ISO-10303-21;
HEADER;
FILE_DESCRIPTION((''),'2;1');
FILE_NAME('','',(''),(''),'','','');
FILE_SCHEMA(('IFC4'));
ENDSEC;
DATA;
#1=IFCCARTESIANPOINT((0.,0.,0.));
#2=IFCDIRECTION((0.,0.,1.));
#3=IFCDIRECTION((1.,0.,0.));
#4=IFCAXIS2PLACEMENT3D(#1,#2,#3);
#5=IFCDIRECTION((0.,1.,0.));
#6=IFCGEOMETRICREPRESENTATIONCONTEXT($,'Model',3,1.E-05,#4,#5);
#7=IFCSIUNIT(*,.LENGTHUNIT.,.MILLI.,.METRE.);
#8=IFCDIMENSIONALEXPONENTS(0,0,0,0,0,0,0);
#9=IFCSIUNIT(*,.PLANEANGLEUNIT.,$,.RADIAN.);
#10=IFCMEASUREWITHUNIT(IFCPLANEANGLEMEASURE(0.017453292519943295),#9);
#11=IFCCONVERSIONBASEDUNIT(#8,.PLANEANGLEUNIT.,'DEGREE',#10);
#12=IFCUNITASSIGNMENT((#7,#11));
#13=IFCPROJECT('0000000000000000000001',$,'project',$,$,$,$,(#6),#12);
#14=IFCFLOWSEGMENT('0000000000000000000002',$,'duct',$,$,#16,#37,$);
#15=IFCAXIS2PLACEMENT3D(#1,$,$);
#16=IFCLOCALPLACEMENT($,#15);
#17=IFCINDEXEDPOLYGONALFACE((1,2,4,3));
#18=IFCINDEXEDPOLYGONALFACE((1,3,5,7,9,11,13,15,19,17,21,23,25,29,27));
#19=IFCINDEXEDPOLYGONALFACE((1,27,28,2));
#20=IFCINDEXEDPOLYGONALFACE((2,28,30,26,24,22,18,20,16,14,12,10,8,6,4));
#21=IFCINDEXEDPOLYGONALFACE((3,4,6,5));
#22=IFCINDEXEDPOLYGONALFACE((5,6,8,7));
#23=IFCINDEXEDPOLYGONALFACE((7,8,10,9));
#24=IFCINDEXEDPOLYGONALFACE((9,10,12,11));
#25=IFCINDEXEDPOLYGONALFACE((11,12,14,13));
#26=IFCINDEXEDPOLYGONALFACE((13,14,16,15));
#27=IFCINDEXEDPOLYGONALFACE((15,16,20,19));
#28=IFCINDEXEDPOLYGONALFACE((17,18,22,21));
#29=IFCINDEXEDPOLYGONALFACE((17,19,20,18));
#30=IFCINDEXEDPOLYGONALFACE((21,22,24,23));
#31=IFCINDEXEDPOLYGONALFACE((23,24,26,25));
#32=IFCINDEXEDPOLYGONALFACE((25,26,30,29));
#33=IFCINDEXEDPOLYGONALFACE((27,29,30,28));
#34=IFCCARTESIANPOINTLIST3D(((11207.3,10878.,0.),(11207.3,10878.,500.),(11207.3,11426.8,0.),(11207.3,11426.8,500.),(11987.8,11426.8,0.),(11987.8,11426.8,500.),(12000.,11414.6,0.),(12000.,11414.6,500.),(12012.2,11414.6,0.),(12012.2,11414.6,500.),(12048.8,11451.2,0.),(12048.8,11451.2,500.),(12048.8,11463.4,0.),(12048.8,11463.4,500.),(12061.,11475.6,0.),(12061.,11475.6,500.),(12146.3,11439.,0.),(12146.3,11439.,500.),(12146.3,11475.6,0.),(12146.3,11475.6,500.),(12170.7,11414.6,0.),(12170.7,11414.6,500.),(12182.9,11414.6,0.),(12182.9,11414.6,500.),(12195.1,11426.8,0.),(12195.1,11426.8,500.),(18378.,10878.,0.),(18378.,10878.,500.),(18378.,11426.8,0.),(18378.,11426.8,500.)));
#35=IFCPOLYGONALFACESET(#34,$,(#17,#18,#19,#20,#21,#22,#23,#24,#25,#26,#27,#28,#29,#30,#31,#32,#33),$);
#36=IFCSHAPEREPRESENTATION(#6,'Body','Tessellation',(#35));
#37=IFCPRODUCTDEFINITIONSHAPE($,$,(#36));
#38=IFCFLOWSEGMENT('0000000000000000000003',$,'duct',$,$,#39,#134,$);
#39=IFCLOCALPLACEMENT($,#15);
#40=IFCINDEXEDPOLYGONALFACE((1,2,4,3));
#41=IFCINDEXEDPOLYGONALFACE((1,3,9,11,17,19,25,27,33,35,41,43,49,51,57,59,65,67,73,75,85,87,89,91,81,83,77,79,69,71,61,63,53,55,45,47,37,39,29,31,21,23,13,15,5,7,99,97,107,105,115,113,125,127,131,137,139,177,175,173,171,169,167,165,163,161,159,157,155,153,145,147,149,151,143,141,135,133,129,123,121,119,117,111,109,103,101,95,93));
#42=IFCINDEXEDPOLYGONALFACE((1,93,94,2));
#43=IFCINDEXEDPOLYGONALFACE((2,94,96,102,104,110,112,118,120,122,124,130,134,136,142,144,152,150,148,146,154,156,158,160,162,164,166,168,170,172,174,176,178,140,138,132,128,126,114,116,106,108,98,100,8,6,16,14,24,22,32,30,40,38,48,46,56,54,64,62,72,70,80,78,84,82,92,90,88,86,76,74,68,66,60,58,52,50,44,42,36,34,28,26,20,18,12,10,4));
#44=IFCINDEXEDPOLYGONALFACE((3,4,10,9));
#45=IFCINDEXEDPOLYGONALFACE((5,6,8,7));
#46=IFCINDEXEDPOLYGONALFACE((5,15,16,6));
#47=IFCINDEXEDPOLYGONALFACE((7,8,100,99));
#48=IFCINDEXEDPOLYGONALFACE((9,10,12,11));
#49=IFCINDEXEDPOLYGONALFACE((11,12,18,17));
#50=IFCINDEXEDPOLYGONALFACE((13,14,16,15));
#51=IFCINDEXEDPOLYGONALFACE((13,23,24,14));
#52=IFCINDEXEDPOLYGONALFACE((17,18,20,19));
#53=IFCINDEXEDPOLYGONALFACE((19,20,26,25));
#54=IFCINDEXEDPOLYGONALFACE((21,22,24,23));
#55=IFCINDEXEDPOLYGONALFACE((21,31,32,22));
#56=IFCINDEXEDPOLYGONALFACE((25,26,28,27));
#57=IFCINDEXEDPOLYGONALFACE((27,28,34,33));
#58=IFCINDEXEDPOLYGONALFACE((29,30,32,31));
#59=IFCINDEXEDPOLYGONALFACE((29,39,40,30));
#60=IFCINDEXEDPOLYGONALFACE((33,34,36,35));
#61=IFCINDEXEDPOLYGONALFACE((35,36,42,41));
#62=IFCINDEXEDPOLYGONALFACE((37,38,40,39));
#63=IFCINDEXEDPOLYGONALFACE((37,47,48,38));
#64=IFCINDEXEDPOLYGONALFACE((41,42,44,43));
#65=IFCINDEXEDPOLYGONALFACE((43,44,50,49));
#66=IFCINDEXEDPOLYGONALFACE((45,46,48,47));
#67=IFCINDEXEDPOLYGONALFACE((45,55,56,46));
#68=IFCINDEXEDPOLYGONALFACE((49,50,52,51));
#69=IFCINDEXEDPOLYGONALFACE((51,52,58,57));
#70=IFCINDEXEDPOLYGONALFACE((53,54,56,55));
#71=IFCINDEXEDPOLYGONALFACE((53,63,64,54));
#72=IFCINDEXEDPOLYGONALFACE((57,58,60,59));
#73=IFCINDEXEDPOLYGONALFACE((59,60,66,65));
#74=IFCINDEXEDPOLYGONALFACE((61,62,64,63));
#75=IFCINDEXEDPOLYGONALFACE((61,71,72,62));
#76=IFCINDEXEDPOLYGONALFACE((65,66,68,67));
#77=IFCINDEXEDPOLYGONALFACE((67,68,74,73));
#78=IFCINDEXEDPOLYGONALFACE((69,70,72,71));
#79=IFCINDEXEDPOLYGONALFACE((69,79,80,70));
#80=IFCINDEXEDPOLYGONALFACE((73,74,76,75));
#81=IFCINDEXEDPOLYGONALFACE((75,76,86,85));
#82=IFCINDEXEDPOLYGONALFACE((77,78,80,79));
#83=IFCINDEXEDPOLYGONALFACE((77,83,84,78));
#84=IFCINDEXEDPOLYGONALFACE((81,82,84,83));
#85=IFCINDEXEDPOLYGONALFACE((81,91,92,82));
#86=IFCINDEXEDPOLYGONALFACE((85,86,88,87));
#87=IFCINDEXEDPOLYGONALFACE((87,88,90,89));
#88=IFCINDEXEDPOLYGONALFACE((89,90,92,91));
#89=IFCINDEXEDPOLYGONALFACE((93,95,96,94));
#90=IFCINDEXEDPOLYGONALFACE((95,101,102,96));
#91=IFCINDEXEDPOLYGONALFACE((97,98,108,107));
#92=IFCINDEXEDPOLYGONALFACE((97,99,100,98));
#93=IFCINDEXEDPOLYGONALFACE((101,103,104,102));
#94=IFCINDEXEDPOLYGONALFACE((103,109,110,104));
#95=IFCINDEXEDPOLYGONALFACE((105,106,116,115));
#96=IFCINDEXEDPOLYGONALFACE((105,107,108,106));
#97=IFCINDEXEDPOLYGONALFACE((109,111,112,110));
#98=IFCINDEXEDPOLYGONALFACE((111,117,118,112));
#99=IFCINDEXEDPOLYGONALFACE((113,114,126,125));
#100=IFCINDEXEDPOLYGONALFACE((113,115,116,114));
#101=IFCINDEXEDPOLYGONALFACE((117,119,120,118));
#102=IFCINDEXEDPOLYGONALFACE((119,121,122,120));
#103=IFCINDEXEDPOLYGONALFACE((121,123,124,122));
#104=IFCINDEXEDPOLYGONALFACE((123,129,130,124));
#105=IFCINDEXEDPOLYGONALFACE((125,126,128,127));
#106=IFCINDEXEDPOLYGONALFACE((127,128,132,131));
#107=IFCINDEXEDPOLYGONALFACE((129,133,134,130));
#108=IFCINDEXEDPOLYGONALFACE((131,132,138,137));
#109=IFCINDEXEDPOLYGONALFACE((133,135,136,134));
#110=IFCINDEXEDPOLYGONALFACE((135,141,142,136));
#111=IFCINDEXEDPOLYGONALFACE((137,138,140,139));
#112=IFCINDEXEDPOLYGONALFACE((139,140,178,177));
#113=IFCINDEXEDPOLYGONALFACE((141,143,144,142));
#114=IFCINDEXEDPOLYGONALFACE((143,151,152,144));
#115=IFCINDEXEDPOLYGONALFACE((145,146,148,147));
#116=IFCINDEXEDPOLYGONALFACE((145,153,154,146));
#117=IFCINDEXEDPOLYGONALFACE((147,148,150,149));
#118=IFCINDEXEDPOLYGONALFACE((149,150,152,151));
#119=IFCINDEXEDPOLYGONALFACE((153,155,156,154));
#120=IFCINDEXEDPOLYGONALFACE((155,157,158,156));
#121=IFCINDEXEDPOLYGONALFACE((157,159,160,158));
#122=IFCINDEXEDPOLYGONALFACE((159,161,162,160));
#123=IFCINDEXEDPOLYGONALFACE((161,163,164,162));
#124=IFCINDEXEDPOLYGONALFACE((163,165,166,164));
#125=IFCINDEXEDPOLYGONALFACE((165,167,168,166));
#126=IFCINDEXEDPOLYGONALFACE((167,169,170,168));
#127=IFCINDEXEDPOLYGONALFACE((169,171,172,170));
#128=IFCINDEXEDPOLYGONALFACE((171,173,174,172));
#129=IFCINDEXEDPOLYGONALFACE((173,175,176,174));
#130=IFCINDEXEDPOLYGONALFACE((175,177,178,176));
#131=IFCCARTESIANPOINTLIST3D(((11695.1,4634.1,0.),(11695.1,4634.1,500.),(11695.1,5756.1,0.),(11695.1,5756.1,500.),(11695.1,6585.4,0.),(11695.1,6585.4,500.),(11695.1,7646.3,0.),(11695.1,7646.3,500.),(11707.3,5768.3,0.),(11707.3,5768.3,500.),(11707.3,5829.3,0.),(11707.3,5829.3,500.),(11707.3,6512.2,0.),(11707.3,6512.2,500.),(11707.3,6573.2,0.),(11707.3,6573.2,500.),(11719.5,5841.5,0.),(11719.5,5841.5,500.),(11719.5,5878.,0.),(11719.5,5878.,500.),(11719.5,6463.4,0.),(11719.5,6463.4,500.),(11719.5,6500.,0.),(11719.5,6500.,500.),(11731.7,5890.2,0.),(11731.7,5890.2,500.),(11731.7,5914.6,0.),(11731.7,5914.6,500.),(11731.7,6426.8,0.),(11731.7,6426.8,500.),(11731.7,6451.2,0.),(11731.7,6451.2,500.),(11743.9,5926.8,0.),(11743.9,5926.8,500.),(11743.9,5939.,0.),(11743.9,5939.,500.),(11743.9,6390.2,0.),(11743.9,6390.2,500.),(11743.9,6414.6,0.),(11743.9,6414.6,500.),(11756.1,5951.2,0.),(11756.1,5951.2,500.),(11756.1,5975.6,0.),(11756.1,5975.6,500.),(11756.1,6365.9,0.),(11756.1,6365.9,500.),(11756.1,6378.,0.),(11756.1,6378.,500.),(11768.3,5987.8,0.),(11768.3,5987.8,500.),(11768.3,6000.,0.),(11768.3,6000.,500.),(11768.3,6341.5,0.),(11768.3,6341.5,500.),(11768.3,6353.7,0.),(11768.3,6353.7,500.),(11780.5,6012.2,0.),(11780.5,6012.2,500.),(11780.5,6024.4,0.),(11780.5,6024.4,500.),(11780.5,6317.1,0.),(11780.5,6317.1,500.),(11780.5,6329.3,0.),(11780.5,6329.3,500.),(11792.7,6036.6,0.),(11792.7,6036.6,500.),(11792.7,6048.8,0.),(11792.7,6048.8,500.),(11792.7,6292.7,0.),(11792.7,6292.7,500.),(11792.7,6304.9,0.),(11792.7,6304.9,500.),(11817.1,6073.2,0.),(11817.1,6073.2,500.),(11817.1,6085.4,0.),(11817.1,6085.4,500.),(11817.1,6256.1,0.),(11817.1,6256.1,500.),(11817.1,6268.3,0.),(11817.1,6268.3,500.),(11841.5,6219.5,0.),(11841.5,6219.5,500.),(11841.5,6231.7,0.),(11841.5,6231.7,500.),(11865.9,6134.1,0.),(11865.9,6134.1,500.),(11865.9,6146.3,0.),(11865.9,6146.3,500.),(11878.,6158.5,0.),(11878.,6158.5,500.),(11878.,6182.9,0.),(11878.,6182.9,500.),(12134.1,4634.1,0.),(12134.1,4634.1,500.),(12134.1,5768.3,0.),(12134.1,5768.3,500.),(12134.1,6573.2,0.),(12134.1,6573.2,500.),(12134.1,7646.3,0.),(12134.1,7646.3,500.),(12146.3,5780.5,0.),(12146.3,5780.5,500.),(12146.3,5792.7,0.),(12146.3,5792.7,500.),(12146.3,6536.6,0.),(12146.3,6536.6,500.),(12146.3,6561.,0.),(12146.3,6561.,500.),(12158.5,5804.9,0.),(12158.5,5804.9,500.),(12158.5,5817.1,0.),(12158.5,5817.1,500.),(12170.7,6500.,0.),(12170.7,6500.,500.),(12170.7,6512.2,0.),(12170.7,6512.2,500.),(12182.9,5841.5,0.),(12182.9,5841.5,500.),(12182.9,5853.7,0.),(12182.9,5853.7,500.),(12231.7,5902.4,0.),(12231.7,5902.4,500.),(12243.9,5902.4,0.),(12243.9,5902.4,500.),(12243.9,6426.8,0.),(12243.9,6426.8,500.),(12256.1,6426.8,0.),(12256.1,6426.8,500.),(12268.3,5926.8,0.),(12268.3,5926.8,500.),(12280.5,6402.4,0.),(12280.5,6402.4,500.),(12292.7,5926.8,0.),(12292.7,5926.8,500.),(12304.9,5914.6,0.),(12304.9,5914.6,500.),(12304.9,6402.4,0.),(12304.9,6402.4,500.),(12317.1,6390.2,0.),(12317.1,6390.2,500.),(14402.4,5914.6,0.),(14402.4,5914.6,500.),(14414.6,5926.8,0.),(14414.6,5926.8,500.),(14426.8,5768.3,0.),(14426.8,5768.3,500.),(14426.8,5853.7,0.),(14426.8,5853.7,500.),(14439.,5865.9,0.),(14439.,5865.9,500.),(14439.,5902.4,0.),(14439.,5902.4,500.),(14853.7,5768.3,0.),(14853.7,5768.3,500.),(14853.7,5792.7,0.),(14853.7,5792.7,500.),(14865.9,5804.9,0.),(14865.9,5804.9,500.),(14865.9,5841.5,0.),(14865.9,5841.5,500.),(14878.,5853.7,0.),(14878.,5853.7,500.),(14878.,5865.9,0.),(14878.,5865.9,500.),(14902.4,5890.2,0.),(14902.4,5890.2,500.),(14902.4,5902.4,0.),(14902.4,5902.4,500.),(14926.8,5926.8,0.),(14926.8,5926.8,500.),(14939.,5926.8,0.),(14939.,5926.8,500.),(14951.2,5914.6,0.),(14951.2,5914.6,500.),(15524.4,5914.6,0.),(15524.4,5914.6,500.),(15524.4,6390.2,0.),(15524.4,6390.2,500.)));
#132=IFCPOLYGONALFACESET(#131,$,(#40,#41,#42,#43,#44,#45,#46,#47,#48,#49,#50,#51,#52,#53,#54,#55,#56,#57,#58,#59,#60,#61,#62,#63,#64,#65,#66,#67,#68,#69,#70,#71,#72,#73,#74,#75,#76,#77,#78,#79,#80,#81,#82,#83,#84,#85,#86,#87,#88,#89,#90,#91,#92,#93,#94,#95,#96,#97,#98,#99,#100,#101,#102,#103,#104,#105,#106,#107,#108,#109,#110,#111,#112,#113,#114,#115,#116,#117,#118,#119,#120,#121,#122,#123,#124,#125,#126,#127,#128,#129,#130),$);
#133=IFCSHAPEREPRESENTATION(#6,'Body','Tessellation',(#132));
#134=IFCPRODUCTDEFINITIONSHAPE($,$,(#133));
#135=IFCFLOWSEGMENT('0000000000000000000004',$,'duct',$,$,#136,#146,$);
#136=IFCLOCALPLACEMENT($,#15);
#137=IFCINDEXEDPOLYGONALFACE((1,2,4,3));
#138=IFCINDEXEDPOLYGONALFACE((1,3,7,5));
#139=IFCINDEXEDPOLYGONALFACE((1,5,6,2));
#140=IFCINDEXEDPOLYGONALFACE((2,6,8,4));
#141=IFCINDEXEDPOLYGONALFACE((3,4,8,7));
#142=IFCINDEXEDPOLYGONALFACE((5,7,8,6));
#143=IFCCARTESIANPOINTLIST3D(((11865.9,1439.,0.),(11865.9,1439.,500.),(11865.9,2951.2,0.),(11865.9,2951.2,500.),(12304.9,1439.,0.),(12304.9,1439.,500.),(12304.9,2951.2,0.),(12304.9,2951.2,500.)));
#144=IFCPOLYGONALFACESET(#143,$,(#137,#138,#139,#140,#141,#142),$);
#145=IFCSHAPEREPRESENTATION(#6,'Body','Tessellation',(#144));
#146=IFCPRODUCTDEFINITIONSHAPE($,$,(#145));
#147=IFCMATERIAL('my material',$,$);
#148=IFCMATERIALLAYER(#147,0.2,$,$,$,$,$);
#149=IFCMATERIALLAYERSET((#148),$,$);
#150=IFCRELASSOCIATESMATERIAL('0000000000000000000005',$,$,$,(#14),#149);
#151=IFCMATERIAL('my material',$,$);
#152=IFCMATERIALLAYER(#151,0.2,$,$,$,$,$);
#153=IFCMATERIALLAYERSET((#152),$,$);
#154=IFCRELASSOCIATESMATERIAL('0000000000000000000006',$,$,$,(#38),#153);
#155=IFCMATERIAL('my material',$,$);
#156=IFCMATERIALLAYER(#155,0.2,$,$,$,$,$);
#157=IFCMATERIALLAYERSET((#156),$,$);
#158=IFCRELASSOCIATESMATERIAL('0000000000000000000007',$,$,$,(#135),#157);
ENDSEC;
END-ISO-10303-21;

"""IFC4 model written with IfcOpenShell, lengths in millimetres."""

from ifc_helpers import new_model, entity, si_unit, converted_unit, direction, origin_with_axes, place, context, project, polyline, outline, extrude, material, layer, layer_set, layer_usage, element, save


model = new_model("IFC4")

# Units and contexts
model_context = context("Model", 3, precision=1e-05, world=origin_with_axes(), true_north=direction((0.0, 1.0, 0.0)))
ifc_project = project(units=[si_unit("LENGTHUNIT", "METRE", prefix="MILLI"), converted_unit("PLANEANGLEUNIT", "DEGREE", entity("IfcPlaneAngleMeasure", 0.017453292519943295), si_unit("PLANEANGLEUNIT", "RADIAN"), dimensions=[0, 0, 0, 0, 0, 0, 0])], contexts=[model_context])

# Flow segments
ifc_material_1 = material(Name="my material")
ifc_layer_1 = layer(ifc_material_1, 0.2)
ifc_layer_set_1 = layer_set([ifc_layer_1])
ifc_layer_usage_1 = layer_usage(ifc_layer_set_1, "AXIS2", "POSITIVE", -0.1)
flow_segment_1_placement = place(None, origin_with_axes())
element("IfcFlowSegment", 1, at=flow_segment_1_placement, material=ifc_layer_usage_1, Name="duct", context=model_context, shape_type="SweptSolid", body=[
    extrude(outline(polyline([(11207.3, 10878.0), (18378.0, 10878.0), (18378.0, 11426.8), (12195.1, 11426.8), (12182.9, 11414.6), (12170.7, 11414.6), (12146.3, 11439.0), (12146.3, 11475.6), (12061.0, 11475.6), (12048.8, 11463.4), (12048.8, 11451.2), (12012.2, 11414.6), (12000.0, 11414.6), (11987.8, 11426.8), (11207.3, 11426.8), (11207.3, 10878.0)])), origin_with_axes(), (0.0, 0.0, 1.0), 500.0),
])
ifc_material_2 = material(Name="my material")
ifc_layer_2 = layer(ifc_material_2, 0.2)
ifc_layer_set_2 = layer_set([ifc_layer_2])
ifc_layer_usage_2 = layer_usage(ifc_layer_set_2, "AXIS2", "POSITIVE", -0.1)
flow_segment_2_placement = place(None, origin_with_axes())
element("IfcFlowSegment", 2, at=flow_segment_2_placement, material=ifc_layer_usage_2, Name="duct", context=model_context, shape_type="SweptSolid", body=[
    extrude(outline(polyline([(11695.1, 4634.1), (12134.1, 4634.1), (12134.1, 5768.3), (12146.3, 5780.5), (12146.3, 5792.7), (12158.5, 5804.9), (12158.5, 5817.1), (12182.9, 5841.5), (12182.9, 5853.7), (12231.7, 5902.4), (12243.9, 5902.4), (12268.3, 5926.8), (12292.7, 5926.8), (12304.9, 5914.6), (14402.4, 5914.6), (14414.6, 5926.8), (14439.0, 5902.4), (14439.0, 5865.9), (14426.8, 5853.7), (14426.8, 5768.3), (14853.7, 5768.3), (14853.7, 5792.7), (14865.9, 5804.9), (14865.9, 5841.5), (14878.0, 5853.7), (14878.0, 5865.9), (14902.4, 5890.2), (14902.4, 5902.4), (14926.8, 5926.8), (14939.0, 5926.8), (14951.2, 5914.6), (15524.4, 5914.6), (15524.4, 6390.2), (12317.1, 6390.2), (12304.9, 6402.4), (12280.5, 6402.4), (12256.1, 6426.8), (12243.9, 6426.8), (12170.7, 6500.0), (12170.7, 6512.2), (12146.3, 6536.6), (12146.3, 6561.0), (12134.1, 6573.2), (12134.1, 7646.3), (11695.1, 7646.3), (11695.1, 6585.4), (11707.3, 6573.2), (11707.3, 6512.2), (11719.5, 6500.0), (11719.5, 6463.4), (11731.7, 6451.2), (11731.7, 6426.8), (11743.9, 6414.6), (11743.9, 6390.2), (11756.1, 6378.0), (11756.1, 6365.9), (11768.3, 6353.7), (11768.3, 6341.5), (11780.5, 6329.3), (11780.5, 6317.1), (11792.7, 6304.9), (11792.7, 6292.7), (11817.1, 6268.3), (11817.1, 6256.1), (11841.5, 6231.7), (11841.5, 6219.5), (11878.0, 6182.9), (11878.0, 6158.5), (11865.9, 6146.3), (11865.9, 6134.1), (11817.1, 6085.4), (11817.1, 6073.2), (11792.7, 6048.8), (11792.7, 6036.6), (11780.5, 6024.4), (11780.5, 6012.2), (11768.3, 6000.0), (11768.3, 5987.8), (11756.1, 5975.6), (11756.1, 5951.2), (11743.9, 5939.0), (11743.9, 5926.8), (11731.7, 5914.6), (11731.7, 5890.2), (11719.5, 5878.0), (11719.5, 5841.5), (11707.3, 5829.3), (11707.3, 5768.3), (11695.1, 5756.1), (11695.1, 4634.1)])), origin_with_axes(), (0.0, 0.0, 1.0), 500.0),
])
ifc_material_3 = material(Name="my material")
ifc_layer_3 = layer(ifc_material_3, 0.2)
ifc_layer_set_3 = layer_set([ifc_layer_3])
ifc_layer_usage_3 = layer_usage(ifc_layer_set_3, "AXIS2", "POSITIVE", -0.1)
flow_segment_3_placement = place(None, origin_with_axes())
element("IfcFlowSegment", 3, at=flow_segment_3_placement, material=ifc_layer_usage_3, Name="duct", context=model_context, shape_type="SweptSolid", body=[
    extrude(outline(polyline([(11865.9, 1439.0), (12304.9, 1439.0), (12304.9, 2951.2), (11865.9, 2951.2), (11865.9, 1439.0)])), origin_with_axes(), (0.0, 0.0, 1.0), 500.0),
])

save(model, "model.ifc")
